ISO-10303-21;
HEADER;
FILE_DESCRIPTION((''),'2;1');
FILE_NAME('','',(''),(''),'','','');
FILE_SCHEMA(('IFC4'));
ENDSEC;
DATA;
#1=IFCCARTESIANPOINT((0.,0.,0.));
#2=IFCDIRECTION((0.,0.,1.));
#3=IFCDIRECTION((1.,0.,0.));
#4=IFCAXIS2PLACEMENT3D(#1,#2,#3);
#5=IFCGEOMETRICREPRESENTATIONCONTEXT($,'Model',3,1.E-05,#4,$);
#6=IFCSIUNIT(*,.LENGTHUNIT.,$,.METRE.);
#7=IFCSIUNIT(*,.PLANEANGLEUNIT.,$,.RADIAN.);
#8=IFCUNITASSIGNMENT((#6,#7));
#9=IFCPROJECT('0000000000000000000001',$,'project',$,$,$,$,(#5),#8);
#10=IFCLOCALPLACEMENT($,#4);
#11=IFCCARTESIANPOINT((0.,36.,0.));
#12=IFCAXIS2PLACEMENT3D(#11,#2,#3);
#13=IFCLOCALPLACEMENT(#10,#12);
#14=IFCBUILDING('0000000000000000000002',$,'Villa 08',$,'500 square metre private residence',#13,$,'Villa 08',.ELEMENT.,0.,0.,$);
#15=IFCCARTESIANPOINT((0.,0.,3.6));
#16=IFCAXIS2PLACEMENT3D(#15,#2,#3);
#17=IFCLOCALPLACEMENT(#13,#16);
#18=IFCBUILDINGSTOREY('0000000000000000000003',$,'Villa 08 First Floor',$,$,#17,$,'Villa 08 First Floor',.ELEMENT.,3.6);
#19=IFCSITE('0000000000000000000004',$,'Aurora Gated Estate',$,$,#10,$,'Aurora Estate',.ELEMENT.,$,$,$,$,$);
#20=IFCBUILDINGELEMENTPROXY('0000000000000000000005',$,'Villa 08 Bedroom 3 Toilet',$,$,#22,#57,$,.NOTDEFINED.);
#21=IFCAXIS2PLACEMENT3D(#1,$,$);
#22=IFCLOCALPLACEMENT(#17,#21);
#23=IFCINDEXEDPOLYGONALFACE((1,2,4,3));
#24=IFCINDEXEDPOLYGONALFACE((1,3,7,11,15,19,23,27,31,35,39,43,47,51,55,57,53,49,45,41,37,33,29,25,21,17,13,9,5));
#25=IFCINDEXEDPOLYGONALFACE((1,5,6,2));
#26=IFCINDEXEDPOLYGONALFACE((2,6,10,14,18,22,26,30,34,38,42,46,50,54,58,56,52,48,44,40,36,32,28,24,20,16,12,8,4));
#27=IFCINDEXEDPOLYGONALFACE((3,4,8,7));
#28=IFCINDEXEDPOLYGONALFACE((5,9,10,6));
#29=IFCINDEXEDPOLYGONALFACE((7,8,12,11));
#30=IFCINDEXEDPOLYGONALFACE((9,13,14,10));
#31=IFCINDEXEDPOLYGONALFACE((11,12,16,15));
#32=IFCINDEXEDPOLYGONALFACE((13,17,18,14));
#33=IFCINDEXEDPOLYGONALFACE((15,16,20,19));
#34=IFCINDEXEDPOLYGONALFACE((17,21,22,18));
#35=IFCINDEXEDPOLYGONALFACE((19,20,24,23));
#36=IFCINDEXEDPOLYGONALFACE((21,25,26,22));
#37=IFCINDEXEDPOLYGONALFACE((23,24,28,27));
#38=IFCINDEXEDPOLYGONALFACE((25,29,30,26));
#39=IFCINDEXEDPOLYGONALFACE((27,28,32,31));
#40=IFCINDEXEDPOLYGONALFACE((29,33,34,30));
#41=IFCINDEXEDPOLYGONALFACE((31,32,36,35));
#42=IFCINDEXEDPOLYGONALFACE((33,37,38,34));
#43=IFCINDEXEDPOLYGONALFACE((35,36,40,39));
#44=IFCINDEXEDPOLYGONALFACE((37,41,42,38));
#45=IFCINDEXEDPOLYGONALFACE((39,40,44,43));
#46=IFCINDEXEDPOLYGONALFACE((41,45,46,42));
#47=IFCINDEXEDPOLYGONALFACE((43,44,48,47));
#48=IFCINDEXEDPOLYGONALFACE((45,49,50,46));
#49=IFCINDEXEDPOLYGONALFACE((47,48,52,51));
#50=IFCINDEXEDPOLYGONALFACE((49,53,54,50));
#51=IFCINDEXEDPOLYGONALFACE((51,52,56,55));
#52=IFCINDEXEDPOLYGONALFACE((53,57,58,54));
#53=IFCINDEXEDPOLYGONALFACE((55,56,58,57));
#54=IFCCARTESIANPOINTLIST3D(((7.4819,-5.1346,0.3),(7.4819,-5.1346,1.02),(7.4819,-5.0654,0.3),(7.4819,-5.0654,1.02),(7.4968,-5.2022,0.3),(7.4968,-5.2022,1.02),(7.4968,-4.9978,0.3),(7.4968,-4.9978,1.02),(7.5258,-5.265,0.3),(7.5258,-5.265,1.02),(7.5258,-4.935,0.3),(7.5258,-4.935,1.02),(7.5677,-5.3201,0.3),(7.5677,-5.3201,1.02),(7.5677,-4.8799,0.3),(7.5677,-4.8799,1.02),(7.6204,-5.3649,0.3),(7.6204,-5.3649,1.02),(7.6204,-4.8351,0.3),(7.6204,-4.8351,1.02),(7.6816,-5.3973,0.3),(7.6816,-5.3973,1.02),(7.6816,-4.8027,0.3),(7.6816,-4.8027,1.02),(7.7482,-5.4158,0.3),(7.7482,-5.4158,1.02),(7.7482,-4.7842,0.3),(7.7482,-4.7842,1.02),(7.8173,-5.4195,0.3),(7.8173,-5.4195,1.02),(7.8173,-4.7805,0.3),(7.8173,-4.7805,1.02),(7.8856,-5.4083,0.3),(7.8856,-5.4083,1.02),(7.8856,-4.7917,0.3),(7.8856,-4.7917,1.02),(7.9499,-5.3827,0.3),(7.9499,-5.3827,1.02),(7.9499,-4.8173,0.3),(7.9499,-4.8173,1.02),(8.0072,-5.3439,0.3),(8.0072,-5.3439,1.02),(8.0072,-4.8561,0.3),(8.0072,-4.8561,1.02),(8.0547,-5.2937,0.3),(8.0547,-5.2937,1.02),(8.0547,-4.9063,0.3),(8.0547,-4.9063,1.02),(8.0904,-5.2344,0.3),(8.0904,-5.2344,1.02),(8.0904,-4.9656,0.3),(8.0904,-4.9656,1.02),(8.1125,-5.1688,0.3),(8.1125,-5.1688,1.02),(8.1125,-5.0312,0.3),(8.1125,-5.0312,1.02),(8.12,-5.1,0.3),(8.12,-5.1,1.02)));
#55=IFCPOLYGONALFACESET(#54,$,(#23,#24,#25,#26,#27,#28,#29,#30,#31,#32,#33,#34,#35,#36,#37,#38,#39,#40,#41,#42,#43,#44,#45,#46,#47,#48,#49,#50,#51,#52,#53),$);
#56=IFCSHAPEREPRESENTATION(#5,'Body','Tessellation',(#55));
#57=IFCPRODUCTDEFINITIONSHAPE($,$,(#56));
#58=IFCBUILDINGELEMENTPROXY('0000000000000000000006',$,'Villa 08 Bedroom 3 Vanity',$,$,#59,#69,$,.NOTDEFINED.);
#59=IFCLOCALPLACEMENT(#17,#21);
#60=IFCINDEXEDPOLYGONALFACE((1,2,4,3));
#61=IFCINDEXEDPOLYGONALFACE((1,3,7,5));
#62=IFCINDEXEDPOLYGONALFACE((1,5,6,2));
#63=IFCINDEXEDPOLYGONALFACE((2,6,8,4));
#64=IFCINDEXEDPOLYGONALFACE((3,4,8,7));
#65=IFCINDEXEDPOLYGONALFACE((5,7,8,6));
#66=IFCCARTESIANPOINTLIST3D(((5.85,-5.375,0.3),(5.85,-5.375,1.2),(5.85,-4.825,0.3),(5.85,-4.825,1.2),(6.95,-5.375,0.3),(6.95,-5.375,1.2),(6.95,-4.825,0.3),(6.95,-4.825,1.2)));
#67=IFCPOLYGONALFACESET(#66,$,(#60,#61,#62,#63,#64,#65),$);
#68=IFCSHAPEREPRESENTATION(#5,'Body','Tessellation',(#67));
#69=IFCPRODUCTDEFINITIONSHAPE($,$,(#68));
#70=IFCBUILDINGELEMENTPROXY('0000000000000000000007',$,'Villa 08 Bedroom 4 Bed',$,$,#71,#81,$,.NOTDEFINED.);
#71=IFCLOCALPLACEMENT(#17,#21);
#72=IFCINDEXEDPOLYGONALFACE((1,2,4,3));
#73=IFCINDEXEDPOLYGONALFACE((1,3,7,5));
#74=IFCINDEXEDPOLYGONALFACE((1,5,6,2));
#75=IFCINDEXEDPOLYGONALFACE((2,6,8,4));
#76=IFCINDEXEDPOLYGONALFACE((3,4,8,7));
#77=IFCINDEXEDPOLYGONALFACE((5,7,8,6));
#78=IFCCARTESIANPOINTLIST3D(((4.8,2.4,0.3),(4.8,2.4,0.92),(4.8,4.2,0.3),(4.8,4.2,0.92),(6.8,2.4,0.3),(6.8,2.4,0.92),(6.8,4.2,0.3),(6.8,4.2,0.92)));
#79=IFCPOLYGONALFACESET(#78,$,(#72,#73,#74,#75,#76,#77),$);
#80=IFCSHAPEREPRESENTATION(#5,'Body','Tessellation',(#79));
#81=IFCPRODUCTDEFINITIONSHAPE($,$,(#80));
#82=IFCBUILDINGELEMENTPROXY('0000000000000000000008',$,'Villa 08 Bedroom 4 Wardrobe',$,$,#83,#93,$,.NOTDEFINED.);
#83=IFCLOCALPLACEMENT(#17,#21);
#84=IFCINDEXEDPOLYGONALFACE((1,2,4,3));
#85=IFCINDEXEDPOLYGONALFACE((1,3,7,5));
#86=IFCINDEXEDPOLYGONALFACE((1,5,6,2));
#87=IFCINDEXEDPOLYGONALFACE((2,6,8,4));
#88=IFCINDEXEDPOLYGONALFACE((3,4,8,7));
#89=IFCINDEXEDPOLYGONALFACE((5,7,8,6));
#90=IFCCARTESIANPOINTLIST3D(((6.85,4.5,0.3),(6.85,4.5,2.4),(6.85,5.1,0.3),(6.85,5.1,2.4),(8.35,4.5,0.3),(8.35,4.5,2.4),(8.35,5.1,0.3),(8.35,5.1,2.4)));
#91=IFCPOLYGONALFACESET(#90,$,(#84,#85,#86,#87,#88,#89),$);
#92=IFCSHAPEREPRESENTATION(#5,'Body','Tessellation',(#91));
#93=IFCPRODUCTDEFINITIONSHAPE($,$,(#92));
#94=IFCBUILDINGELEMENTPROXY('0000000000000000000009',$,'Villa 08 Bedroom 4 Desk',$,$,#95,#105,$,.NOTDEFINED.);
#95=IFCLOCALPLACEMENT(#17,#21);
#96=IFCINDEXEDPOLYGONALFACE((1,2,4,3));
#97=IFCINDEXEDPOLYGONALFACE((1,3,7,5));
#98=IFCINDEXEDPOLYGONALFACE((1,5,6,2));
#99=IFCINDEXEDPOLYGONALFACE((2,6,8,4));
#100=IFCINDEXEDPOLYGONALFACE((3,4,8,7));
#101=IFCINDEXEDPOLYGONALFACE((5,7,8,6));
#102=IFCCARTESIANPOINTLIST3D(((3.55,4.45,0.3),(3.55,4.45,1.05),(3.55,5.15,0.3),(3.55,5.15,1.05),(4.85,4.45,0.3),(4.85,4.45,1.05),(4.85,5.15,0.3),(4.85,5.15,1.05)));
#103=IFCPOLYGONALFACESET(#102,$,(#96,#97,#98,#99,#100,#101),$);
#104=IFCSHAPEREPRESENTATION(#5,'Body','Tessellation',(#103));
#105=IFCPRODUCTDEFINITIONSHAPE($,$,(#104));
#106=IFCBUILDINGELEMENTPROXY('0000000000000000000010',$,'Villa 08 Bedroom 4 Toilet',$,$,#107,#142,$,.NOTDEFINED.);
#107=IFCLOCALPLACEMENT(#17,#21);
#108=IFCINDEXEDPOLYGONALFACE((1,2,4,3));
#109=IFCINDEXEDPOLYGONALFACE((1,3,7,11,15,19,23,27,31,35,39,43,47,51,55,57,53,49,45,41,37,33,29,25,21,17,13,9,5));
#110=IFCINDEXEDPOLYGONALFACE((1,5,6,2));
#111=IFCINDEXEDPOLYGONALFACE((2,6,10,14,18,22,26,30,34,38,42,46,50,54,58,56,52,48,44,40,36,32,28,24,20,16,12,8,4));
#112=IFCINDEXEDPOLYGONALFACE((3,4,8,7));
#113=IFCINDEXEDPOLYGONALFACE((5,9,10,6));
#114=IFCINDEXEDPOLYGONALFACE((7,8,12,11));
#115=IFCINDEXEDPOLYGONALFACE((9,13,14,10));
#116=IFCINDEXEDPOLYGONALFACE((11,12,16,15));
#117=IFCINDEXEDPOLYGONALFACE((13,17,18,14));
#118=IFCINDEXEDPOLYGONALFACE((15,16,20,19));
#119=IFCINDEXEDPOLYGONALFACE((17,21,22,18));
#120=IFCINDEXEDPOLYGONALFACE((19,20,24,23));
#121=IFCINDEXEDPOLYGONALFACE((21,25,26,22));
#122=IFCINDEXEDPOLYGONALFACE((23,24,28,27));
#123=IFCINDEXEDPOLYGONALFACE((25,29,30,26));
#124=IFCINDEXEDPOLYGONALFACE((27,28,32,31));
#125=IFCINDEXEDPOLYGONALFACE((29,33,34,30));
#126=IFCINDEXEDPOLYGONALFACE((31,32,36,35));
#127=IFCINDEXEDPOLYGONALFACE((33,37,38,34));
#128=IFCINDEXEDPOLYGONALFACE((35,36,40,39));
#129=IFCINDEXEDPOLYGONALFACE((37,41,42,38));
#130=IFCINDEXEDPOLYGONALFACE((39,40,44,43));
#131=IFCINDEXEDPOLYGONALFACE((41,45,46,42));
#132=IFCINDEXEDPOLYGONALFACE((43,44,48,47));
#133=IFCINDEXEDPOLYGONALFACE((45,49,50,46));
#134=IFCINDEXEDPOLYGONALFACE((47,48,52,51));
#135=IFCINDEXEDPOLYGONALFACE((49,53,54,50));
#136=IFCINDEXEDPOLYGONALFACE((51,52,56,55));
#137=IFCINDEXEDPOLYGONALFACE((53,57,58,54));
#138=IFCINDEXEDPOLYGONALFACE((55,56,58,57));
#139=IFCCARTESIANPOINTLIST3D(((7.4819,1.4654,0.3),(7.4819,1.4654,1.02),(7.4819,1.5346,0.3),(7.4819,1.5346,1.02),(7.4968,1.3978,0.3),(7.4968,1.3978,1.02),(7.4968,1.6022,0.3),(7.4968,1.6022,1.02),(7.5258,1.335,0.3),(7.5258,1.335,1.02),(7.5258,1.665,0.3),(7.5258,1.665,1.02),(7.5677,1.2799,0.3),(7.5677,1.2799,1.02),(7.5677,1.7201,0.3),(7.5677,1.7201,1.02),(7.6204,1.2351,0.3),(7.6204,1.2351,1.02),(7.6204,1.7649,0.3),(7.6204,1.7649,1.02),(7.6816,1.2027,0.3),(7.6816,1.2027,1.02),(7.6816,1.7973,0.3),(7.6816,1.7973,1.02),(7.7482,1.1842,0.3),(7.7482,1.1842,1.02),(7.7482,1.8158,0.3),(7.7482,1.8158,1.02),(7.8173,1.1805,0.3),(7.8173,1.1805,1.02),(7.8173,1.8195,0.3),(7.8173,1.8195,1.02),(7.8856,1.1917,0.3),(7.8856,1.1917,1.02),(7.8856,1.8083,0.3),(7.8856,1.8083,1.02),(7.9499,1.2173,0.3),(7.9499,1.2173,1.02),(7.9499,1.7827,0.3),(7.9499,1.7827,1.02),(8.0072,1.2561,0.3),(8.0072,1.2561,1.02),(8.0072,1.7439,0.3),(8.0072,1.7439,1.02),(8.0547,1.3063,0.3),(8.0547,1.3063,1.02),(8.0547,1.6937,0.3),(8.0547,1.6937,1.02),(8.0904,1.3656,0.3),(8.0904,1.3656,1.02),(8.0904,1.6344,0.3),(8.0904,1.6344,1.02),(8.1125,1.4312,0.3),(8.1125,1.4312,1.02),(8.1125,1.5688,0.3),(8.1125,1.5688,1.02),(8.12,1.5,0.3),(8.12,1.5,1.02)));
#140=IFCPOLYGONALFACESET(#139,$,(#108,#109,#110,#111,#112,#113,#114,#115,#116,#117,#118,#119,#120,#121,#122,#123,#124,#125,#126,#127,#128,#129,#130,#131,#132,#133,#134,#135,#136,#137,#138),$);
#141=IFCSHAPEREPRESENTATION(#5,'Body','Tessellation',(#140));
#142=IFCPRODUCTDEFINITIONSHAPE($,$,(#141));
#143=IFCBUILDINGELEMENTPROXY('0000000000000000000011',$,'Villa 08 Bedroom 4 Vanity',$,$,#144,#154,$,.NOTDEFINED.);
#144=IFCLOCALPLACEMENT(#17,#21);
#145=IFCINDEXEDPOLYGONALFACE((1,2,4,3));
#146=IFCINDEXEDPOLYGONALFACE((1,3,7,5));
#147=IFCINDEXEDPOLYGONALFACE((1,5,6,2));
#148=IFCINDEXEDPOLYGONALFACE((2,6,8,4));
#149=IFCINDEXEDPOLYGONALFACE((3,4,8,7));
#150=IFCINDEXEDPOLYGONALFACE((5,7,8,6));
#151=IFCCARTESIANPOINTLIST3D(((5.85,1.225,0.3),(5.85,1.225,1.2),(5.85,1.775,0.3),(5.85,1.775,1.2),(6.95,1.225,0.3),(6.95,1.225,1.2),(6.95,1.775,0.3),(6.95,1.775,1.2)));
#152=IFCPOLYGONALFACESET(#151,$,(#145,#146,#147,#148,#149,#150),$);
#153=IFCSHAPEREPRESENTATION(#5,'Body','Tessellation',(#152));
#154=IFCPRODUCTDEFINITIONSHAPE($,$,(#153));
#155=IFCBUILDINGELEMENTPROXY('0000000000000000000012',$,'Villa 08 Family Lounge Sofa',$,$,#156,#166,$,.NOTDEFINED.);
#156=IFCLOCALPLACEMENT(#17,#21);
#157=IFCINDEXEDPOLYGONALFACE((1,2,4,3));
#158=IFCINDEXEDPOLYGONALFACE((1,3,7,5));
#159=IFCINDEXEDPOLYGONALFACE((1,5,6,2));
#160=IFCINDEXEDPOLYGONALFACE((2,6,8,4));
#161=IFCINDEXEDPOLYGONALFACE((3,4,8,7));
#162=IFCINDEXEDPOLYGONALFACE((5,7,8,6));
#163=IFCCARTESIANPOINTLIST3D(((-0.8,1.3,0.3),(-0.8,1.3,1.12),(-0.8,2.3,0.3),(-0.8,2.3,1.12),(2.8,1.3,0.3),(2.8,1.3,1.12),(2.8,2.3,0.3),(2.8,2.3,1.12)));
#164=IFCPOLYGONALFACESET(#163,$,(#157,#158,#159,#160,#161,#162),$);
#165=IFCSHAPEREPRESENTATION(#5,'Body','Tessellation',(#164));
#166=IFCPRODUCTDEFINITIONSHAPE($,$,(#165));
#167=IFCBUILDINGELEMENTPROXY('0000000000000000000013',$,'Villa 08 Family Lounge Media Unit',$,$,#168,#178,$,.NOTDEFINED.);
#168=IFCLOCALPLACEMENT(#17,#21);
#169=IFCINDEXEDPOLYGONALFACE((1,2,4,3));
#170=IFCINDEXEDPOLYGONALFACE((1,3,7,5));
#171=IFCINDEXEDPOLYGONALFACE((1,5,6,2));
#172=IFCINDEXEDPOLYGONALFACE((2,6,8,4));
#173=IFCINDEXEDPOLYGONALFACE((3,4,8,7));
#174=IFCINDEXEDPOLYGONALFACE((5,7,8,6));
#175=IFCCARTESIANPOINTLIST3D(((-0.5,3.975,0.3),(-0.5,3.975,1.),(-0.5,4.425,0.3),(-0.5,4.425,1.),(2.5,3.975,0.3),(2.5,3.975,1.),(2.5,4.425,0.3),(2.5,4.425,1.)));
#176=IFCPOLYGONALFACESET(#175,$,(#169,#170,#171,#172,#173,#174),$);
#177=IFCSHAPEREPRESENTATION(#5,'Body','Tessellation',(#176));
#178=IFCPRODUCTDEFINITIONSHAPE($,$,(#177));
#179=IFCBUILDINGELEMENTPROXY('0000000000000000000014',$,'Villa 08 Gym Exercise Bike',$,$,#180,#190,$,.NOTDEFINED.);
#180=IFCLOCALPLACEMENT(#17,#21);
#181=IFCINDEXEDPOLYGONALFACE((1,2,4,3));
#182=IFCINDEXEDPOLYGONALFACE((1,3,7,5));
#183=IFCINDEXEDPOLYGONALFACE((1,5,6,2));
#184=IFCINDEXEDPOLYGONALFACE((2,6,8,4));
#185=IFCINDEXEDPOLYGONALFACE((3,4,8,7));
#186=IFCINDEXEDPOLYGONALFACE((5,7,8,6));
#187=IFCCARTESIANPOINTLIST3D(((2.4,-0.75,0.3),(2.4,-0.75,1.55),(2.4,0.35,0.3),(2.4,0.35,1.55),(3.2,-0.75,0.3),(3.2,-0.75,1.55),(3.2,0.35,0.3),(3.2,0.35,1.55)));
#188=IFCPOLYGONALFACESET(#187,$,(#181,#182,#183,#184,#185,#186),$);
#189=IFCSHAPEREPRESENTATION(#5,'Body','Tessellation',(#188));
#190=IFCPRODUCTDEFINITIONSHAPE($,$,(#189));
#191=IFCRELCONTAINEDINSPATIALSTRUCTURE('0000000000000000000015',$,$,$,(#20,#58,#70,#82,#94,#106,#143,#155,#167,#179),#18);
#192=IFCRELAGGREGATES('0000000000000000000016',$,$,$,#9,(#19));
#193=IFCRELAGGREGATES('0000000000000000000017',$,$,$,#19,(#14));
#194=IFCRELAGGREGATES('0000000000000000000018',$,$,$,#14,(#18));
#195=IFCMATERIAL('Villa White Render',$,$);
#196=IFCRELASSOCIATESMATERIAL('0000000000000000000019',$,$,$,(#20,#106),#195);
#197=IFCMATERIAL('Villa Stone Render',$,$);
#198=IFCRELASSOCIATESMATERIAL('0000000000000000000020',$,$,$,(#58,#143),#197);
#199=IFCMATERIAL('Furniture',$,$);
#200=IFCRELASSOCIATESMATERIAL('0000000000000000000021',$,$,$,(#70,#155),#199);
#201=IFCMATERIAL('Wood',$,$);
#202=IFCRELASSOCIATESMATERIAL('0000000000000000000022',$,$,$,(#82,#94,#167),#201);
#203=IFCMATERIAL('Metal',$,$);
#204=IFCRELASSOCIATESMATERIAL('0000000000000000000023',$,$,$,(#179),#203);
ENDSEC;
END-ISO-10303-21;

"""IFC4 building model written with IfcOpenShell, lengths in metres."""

from ifc_helpers import new_model, si_unit, frame, origin_with_axes, origin_2d_with_axis, place, context, project, spatial, rectangle, circle, extrude, material, element, save


model = new_model("IFC4")

# Units and contexts
model_context = context("Model", 3, precision=1e-05, world=origin_with_axes())
ifc_project = project(units=[si_unit("LENGTHUNIT", "METRE"), si_unit("PLANEANGLEUNIT", "RADIAN")], contexts=[model_context])

# Site, building, storey
site_placement = place(None, origin_with_axes())
site = spatial("IfcSite", under=ifc_project, at=site_placement, Name="Aurora Gated Estate", LongName="Aurora Estate", CompositionType="ELEMENT")
building_placement = place(site_placement, frame((0.0, 36.0, 0.0), z_axis=(0.0, 0.0, 1.0), x_axis=(1.0, 0.0, 0.0)))
building = spatial("IfcBuilding", under=site, at=building_placement, Name="Villa 08", ObjectType="500 square metre private residence", LongName="Villa 08", CompositionType="ELEMENT", ElevationOfRefHeight=0.0, ElevationOfTerrain=0.0)
storey_placement = place(building_placement, frame((0.0, 0.0, 3.6), z_axis=(0.0, 0.0, 1.0), x_axis=(1.0, 0.0, 0.0)))
storey = spatial("IfcBuildingStorey", under=building, at=storey_placement, Name="Villa 08 First Floor", LongName="Villa 08 First Floor", CompositionType="ELEMENT", Elevation=3.6)

# Building element proxies
ifc_material_1 = material(Name="Wood")
ifc_material_2 = material(Name="Villa White Render")
ifc_material_3 = material(Name="Villa Stone Render")
ifc_material_4 = material(Name="Furniture")
proxy_1_placement = place(storey_placement, frame((7.8, -5.1, 0.3), z_axis=(0.0, 0.0, 1.0), x_axis=(1.0, 0.0, 0.0)))
element("IfcBuildingElementProxy", 1, at=proxy_1_placement, inside=storey, material=ifc_material_2, Name="Villa 08 Bedroom 3 Toilet", PredefinedType="NOTDEFINED", context=model_context, shape_type="SweptSolid", body=[
    extrude(circle(Radius=0.32, at=origin_2d_with_axis()), origin_with_axes(), (0.0, 0.0, 1.0), 0.72),
])
proxy_2_placement = place(storey_placement, frame((6.4, -5.1, 0.3), z_axis=(0.0, 0.0, 1.0), x_axis=(1.0, 0.0, 0.0)))
element("IfcBuildingElementProxy", 2, at=proxy_2_placement, inside=storey, material=ifc_material_3, Name="Villa 08 Bedroom 3 Vanity", PredefinedType="NOTDEFINED", context=model_context, shape_type="SweptSolid", body=[
    extrude(rectangle(XDim=1.1, YDim=0.55, at=origin_2d_with_axis()), origin_with_axes(), (0.0, 0.0, 1.0), 0.9),
])
proxy_3_placement = place(storey_placement, frame((5.8, 3.3, 0.3), z_axis=(0.0, 0.0, 1.0), x_axis=(1.0, 0.0, 0.0)))
element("IfcBuildingElementProxy", 3, at=proxy_3_placement, inside=storey, material=ifc_material_4, Name="Villa 08 Bedroom 4 Bed", PredefinedType="NOTDEFINED", context=model_context, shape_type="SweptSolid", body=[
    extrude(rectangle(XDim=2.0, YDim=1.8, at=origin_2d_with_axis()), origin_with_axes(), (0.0, 0.0, 1.0), 0.62),
])
proxy_4_placement = place(storey_placement, frame((7.6, 4.8, 0.3), z_axis=(0.0, 0.0, 1.0), x_axis=(1.0, 0.0, 0.0)))
element("IfcBuildingElementProxy", 4, at=proxy_4_placement, inside=storey, material=ifc_material_1, Name="Villa 08 Bedroom 4 Wardrobe", PredefinedType="NOTDEFINED", context=model_context, shape_type="SweptSolid", body=[
    extrude(rectangle(XDim=1.5, YDim=0.6, at=origin_2d_with_axis()), origin_with_axes(), (0.0, 0.0, 1.0), 2.1),
])
proxy_5_placement = place(storey_placement, frame((4.2, 4.8, 0.3), z_axis=(0.0, 0.0, 1.0), x_axis=(1.0, 0.0, 0.0)))
element("IfcBuildingElementProxy", 5, at=proxy_5_placement, inside=storey, material=ifc_material_1, Name="Villa 08 Bedroom 4 Desk", PredefinedType="NOTDEFINED", context=model_context, shape_type="SweptSolid", body=[
    extrude(rectangle(XDim=1.3, YDim=0.7, at=origin_2d_with_axis()), origin_with_axes(), (0.0, 0.0, 1.0), 0.75),
])
proxy_6_placement = place(storey_placement, frame((7.8, 1.5, 0.3), z_axis=(0.0, 0.0, 1.0), x_axis=(1.0, 0.0, 0.0)))
element("IfcBuildingElementProxy", 6, at=proxy_6_placement, inside=storey, material=ifc_material_2, Name="Villa 08 Bedroom 4 Toilet", PredefinedType="NOTDEFINED", context=model_context, shape_type="SweptSolid", body=[
    extrude(circle(Radius=0.32, at=origin_2d_with_axis()), origin_with_axes(), (0.0, 0.0, 1.0), 0.72),
])
proxy_7_placement = place(storey_placement, frame((6.4, 1.5, 0.3), z_axis=(0.0, 0.0, 1.0), x_axis=(1.0, 0.0, 0.0)))
element("IfcBuildingElementProxy", 7, at=proxy_7_placement, inside=storey, material=ifc_material_3, Name="Villa 08 Bedroom 4 Vanity", PredefinedType="NOTDEFINED", context=model_context, shape_type="SweptSolid", body=[
    extrude(rectangle(XDim=1.1, YDim=0.55, at=origin_2d_with_axis()), origin_with_axes(), (0.0, 0.0, 1.0), 0.9),
])
proxy_8_placement = place(storey_placement, frame((1.0, 1.8, 0.3), z_axis=(0.0, 0.0, 1.0), x_axis=(1.0, 0.0, 0.0)))
element("IfcBuildingElementProxy", 8, at=proxy_8_placement, inside=storey, material=ifc_material_4, Name="Villa 08 Family Lounge Sofa", PredefinedType="NOTDEFINED", context=model_context, shape_type="SweptSolid", body=[
    extrude(rectangle(XDim=3.6, YDim=1.0, at=origin_2d_with_axis()), origin_with_axes(), (0.0, 0.0, 1.0), 0.82),
])
proxy_9_placement = place(storey_placement, frame((1.0, 4.2, 0.3), z_axis=(0.0, 0.0, 1.0), x_axis=(1.0, 0.0, 0.0)))
element("IfcBuildingElementProxy", 9, at=proxy_9_placement, inside=storey, material=ifc_material_1, Name="Villa 08 Family Lounge Media Unit", PredefinedType="NOTDEFINED", context=model_context, shape_type="SweptSolid", body=[
    extrude(rectangle(XDim=3.0, YDim=0.45, at=origin_2d_with_axis()), origin_with_axes(), (0.0, 0.0, 1.0), 0.7),
])
ifc_material_5 = material(Name="Metal")
proxy_10_placement = place(storey_placement, frame((2.8, -0.2, 0.3), z_axis=(0.0, 0.0, 1.0), x_axis=(1.0, 0.0, 0.0)))
element("IfcBuildingElementProxy", 10, at=proxy_10_placement, inside=storey, material=ifc_material_5, Name="Villa 08 Gym Exercise Bike", PredefinedType="NOTDEFINED", context=model_context, shape_type="SweptSolid", body=[
    extrude(rectangle(XDim=0.8, YDim=1.1, at=origin_2d_with_axis()), origin_with_axes(), (0.0, 0.0, 1.0), 1.25),
])

save(model, "model.ifc")
